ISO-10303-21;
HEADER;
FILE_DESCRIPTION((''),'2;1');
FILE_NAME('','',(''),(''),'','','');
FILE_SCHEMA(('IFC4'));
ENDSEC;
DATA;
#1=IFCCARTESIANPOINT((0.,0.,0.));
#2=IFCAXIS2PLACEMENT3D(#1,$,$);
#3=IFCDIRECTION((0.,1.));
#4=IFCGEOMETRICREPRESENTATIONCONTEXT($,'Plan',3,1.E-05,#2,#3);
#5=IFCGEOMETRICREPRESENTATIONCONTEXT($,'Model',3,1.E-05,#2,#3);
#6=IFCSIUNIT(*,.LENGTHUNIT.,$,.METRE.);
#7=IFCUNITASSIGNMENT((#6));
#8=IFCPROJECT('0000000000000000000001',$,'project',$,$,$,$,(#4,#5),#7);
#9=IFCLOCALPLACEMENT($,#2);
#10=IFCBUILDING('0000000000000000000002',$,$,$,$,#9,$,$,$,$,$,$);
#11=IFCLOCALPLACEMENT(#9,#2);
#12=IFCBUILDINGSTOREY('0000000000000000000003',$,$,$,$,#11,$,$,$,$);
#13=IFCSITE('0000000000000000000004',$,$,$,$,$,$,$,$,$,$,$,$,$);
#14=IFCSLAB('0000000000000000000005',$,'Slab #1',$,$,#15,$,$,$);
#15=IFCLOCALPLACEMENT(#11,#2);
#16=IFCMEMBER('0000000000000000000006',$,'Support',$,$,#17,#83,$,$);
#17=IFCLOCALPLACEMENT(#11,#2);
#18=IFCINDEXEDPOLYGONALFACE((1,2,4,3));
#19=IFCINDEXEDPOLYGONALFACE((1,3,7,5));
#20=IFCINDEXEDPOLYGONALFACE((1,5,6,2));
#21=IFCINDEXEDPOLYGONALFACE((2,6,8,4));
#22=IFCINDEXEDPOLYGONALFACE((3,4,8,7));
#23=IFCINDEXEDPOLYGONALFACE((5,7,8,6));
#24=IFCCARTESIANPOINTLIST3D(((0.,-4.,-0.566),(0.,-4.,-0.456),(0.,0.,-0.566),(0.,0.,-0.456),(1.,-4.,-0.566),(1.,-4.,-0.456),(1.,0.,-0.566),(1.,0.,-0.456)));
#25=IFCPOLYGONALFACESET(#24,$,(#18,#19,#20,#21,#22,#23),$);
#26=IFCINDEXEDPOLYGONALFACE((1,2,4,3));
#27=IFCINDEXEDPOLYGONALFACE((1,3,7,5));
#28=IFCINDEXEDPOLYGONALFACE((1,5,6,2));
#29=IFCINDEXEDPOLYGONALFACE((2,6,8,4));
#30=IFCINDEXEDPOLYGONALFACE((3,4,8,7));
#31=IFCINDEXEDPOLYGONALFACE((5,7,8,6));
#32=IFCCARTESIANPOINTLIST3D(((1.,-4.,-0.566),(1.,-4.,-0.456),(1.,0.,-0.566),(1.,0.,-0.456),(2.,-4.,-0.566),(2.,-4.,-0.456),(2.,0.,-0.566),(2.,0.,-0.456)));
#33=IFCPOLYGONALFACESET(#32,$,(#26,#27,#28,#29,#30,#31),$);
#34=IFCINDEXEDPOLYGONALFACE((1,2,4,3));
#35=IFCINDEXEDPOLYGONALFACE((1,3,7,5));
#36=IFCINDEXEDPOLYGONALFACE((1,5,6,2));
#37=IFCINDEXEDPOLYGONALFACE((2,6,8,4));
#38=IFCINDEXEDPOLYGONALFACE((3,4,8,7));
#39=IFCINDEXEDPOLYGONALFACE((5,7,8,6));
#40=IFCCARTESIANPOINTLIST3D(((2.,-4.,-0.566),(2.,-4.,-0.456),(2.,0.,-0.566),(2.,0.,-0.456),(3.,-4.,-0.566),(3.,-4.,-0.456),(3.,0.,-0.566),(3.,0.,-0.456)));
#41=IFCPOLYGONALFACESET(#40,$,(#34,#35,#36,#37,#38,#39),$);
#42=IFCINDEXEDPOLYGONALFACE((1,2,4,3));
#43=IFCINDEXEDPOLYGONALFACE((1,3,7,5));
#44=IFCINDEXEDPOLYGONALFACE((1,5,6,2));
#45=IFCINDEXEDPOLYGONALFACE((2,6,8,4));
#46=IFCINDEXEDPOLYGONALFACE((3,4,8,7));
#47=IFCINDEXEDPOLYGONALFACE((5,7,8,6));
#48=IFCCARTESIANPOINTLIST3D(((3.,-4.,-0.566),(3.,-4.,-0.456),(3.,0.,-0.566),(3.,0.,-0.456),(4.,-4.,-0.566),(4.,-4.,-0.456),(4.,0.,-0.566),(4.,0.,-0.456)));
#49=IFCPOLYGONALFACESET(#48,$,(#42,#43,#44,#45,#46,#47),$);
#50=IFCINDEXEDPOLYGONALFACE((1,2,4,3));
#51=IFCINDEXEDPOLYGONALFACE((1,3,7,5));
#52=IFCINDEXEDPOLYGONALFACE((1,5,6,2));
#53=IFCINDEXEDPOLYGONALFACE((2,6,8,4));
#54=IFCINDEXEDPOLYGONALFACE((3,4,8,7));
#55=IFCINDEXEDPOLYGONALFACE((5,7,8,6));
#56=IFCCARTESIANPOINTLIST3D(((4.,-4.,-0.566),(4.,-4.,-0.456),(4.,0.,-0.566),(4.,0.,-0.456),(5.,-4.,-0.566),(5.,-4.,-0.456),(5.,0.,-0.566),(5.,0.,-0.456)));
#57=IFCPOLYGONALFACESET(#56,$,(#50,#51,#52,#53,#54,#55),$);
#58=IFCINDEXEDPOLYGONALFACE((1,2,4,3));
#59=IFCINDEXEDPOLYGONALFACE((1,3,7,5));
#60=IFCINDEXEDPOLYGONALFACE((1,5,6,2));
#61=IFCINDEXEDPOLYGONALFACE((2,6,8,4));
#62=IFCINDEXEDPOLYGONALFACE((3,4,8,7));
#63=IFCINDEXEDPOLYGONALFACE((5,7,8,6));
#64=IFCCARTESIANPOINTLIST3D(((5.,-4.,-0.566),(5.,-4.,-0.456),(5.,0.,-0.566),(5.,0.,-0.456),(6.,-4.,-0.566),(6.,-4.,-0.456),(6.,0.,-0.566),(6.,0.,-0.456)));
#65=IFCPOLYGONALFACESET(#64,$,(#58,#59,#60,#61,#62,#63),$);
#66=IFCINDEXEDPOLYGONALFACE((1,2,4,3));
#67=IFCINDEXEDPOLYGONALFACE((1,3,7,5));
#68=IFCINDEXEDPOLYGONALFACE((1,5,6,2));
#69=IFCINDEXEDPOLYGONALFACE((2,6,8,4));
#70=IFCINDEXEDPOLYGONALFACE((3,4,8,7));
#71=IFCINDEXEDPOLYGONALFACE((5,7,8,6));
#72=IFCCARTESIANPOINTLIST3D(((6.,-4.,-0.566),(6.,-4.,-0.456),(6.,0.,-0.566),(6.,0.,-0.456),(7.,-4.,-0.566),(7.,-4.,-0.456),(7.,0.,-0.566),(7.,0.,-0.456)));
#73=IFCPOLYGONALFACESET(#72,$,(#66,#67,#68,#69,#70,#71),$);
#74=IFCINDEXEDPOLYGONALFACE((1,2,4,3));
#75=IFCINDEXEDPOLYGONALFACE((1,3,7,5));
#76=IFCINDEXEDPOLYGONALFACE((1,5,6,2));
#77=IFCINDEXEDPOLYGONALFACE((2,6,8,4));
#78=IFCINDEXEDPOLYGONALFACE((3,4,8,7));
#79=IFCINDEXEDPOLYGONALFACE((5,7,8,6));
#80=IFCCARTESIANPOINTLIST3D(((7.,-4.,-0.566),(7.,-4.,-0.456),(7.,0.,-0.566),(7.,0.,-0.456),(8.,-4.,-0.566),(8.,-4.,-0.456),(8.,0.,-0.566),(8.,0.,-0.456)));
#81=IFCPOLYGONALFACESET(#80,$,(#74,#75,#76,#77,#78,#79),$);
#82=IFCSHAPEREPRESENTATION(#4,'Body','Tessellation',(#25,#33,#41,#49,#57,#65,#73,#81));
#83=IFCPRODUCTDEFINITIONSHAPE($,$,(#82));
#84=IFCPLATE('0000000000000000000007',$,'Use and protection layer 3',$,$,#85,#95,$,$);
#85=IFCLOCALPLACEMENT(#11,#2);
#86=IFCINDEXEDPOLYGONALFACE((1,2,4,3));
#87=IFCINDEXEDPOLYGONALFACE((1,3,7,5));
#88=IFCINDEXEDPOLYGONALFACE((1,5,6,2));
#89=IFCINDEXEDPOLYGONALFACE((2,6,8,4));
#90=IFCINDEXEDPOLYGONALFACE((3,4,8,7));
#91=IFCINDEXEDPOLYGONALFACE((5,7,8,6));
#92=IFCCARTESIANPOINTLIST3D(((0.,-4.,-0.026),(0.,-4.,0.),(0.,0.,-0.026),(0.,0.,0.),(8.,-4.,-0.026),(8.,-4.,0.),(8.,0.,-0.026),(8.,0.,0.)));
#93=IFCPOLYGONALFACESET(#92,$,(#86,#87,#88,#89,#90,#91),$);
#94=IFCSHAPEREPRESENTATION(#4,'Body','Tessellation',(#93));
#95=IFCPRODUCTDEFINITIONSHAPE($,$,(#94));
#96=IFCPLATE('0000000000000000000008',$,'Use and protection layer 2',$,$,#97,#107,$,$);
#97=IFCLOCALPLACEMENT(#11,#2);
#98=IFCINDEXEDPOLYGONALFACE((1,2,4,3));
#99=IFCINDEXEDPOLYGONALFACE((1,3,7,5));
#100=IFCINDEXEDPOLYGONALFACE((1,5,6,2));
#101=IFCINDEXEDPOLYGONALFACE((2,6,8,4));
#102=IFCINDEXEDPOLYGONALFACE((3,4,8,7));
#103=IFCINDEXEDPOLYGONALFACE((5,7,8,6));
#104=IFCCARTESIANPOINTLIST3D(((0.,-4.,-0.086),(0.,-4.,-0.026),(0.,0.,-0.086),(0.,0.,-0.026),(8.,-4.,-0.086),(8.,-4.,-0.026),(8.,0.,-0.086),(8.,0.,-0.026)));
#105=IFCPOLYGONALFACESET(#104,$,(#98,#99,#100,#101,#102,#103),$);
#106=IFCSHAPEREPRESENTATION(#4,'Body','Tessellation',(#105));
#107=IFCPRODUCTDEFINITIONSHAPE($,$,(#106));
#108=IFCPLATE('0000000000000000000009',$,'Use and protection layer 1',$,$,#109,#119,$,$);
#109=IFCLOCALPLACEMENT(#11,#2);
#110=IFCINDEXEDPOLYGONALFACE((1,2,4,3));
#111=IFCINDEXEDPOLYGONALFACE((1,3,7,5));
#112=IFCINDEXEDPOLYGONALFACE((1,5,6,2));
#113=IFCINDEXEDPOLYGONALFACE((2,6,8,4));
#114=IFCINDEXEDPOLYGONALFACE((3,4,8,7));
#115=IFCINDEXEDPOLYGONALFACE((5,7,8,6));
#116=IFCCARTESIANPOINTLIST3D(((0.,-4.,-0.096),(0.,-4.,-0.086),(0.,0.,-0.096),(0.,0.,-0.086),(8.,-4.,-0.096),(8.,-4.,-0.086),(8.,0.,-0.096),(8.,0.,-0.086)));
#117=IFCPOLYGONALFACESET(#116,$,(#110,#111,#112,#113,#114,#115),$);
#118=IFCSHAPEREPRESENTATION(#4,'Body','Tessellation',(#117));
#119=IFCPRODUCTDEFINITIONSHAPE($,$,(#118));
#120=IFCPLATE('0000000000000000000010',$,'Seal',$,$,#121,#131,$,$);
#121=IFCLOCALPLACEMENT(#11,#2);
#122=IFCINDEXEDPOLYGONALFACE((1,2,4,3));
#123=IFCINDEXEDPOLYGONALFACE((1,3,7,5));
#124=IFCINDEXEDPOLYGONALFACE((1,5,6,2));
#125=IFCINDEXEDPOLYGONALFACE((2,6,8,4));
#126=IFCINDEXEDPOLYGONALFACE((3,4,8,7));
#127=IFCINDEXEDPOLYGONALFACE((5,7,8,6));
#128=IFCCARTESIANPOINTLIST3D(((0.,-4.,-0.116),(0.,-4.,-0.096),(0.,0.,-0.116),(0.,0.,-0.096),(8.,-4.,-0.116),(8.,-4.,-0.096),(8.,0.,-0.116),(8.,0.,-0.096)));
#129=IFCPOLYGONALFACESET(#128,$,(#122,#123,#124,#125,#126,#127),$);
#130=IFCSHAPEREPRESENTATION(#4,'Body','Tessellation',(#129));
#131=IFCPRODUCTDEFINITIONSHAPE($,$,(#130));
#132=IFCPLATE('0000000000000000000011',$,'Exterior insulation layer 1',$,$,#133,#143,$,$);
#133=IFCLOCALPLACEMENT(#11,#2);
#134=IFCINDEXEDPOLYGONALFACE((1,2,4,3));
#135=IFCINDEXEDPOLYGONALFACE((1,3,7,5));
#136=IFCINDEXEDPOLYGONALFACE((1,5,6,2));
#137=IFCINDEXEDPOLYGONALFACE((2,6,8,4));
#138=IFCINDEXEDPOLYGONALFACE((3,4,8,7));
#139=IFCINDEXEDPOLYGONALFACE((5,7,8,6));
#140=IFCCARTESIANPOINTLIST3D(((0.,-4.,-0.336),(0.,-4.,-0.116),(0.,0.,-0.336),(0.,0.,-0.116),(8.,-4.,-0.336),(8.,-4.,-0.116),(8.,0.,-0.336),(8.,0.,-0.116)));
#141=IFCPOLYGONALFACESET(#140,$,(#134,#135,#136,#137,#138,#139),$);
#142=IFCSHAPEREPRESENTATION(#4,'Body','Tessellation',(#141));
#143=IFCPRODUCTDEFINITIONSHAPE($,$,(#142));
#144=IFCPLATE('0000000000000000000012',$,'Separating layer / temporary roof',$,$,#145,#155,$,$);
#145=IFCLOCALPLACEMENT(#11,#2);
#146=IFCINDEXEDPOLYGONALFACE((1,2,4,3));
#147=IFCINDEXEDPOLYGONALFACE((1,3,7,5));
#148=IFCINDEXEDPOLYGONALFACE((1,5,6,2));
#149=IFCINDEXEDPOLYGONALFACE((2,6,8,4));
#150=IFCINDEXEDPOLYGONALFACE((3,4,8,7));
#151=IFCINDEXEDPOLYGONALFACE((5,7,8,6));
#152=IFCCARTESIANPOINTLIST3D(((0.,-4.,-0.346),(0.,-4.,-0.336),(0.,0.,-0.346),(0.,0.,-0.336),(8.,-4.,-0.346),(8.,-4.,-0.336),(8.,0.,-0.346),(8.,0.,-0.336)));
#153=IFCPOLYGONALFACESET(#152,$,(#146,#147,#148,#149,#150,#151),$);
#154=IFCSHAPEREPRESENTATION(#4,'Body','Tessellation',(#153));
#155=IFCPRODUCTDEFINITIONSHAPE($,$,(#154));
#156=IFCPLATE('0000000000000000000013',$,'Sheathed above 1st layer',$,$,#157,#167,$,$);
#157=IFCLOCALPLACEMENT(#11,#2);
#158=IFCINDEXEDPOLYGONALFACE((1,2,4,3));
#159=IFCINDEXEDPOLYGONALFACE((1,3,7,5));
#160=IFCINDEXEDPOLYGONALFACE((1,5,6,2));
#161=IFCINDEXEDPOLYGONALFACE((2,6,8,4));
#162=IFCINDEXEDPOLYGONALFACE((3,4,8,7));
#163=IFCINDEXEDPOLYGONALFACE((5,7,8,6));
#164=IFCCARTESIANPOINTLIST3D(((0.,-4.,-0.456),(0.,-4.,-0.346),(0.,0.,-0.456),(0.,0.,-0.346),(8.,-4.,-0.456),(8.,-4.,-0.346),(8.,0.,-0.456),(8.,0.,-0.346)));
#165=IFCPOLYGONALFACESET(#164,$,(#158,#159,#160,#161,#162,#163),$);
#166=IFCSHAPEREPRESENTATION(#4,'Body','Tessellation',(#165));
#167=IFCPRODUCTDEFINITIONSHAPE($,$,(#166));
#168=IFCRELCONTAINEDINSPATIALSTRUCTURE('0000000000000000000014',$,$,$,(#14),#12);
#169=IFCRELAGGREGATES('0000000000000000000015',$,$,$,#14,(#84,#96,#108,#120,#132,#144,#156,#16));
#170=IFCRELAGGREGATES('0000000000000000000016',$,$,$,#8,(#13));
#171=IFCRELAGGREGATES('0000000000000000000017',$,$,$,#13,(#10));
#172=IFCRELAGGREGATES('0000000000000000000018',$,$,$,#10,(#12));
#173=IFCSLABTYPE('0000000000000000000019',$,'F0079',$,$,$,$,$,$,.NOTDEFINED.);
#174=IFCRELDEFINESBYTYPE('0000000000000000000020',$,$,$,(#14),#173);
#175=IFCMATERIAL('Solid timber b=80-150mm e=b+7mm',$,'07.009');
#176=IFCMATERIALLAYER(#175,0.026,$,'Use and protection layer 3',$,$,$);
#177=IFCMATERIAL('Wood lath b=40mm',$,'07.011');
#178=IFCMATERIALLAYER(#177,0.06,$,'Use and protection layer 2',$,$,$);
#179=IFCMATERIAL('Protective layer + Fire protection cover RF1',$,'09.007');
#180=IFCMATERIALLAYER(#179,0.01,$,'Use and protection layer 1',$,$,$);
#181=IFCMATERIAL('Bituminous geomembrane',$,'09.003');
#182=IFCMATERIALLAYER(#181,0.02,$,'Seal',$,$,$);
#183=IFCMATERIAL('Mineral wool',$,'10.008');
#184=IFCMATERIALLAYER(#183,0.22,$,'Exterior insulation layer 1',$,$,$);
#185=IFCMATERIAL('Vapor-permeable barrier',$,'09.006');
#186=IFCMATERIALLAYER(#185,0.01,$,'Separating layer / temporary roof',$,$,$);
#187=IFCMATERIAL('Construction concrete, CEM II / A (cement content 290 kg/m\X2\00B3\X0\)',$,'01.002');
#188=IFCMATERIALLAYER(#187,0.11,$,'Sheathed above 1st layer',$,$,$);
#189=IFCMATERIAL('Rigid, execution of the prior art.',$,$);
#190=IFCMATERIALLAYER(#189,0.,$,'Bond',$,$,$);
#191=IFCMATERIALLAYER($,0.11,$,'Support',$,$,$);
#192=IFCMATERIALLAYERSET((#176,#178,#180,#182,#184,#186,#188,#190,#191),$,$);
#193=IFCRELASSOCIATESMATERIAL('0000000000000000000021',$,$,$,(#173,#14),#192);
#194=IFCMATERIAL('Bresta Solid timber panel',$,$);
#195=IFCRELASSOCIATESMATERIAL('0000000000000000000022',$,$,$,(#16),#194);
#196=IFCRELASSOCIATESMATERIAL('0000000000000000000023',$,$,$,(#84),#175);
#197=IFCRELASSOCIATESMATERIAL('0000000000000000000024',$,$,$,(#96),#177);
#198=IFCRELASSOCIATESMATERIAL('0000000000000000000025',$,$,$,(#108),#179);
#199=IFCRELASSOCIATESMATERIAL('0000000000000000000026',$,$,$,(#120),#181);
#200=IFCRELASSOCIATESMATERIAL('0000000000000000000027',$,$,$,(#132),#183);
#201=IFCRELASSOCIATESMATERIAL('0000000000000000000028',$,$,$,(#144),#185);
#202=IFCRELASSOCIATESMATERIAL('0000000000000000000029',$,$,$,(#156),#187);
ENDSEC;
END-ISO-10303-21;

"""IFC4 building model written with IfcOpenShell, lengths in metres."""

from ifc_helpers import new_model, si_unit, direction, frame, frame_2d, origin, origin_with_axes, place, context, project, spatial, rectangle, extrude, material, layer, layer_set, type_object, element, aggregate, save


model = new_model("IFC4")

# Units and contexts
plan_context = context("Plan", 3, precision=1e-05, world=origin(), true_north=direction((0.0, 1.0)))
model_context = context("Model", 3, precision=1e-05, world=origin(), true_north=direction((0.0, 1.0)))
ifc_project = project(units=[si_unit("LENGTHUNIT", "METRE")], contexts=[plan_context, model_context])

# Site, building, storey
site = spatial("IfcSite", under=ifc_project)
building_placement = place(None, origin())
building = spatial("IfcBuilding", under=site, at=building_placement)
storey_placement = place(building_placement, origin())
storey = spatial("IfcBuildingStorey", under=building, at=storey_placement)

# Slab, member, plates
ifc_material_1 = material(Name="Solid timber b=80-150mm e=b+7mm", Category="07.009")
ifc_layer_1 = layer(ifc_material_1, 0.026, Name="Use and protection layer 3")
ifc_material_2 = material(Name="Wood lath b=40mm", Category="07.011")
ifc_layer_2 = layer(ifc_material_2, 0.06, Name="Use and protection layer 2")
ifc_material_3 = material(Name="Protective layer + Fire protection cover RF1", Category="09.007")
ifc_layer_3 = layer(ifc_material_3, 0.01, Name="Use and protection layer 1")
ifc_material_4 = material(Name="Bituminous geomembrane", Category="09.003")
ifc_layer_4 = layer(ifc_material_4, 0.02, Name="Seal")
ifc_material_5 = material(Name="Mineral wool", Category="10.008")
ifc_layer_5 = layer(ifc_material_5, 0.22, Name="Exterior insulation layer 1")
ifc_material_6 = material(Name="Vapor-permeable barrier", Category="09.006")
ifc_layer_6 = layer(ifc_material_6, 0.01, Name="Separating layer / temporary roof")
ifc_material_7 = material(Name="Construction concrete, CEM II / A (cement content 290 kg/m³)", Category="01.002")
ifc_layer_7 = layer(ifc_material_7, 0.11, Name="Sheathed above 1st layer")
ifc_material_8 = material(Name="Rigid, execution of the prior art.")
ifc_layer_8 = layer(ifc_material_8, 0.0, Name="Bond")
ifc_layer_9 = layer(None, 0.11, Name="Support")
ifc_layer_set = layer_set([ifc_layer_1, ifc_layer_2, ifc_layer_3, ifc_layer_4, ifc_layer_5, ifc_layer_6, ifc_layer_7, ifc_layer_8, ifc_layer_9])
slab_type = type_object("IfcSlabType", Name="F0079", PredefinedType="NOTDEFINED", material=ifc_layer_set)
slab_placement = place(None, frame((0.0, 0.0, 0.0), z_axis=(0.0, 0.0, -1.0), x_axis=(1.0, 0.0, 0.0)))
slab = element("IfcSlab", 1, at=slab_placement, inside=storey, type_object=slab_type, material=ifc_layer_set, Name="Slab #1")
ifc_material_9 = material(Name="Bresta Solid timber panel")
member_placement = place(slab_placement, origin())
member = element("IfcMember", 2, at=member_placement, material=ifc_material_9, Name="Support", context=plan_context, shape_type="SweptSolid", body=[
    extrude(rectangle(XDim=1.0, YDim=0.11, at=frame_2d((0.5, 0.055), x_axis=(1.0, 0.0))), frame((0.0, 4.0, 0.456), z_axis=(0.0, -1.0, 0.0), x_axis=(1.0, 0.0, 0.0)), (0.0, 0.0, 1.0), 4.0),
    extrude(rectangle(XDim=1.0, YDim=0.11, at=frame_2d((0.5, 0.055), x_axis=(1.0, 0.0))), frame((1.0, 4.0, 0.456), z_axis=(0.0, -1.0, 0.0), x_axis=(1.0, 0.0, 0.0)), (0.0, 0.0, 1.0), 4.0),
    extrude(rectangle(XDim=1.0, YDim=0.11, at=frame_2d((0.5, 0.055), x_axis=(1.0, 0.0))), frame((2.0, 4.0, 0.456), z_axis=(0.0, -1.0, 0.0), x_axis=(1.0, 0.0, 0.0)), (0.0, 0.0, 1.0), 4.0),
    extrude(rectangle(XDim=1.0, YDim=0.11, at=frame_2d((0.5, 0.055), x_axis=(1.0, 0.0))), frame((3.0, 4.0, 0.456), z_axis=(0.0, -1.0, 0.0), x_axis=(1.0, 0.0, 0.0)), (0.0, 0.0, 1.0), 4.0),
    extrude(rectangle(XDim=1.0, YDim=0.11, at=frame_2d((0.5, 0.055), x_axis=(1.0, 0.0))), frame((4.0, 4.0, 0.456), z_axis=(0.0, -1.0, 0.0), x_axis=(1.0, 0.0, 0.0)), (0.0, 0.0, 1.0), 4.0),
    extrude(rectangle(XDim=1.0, YDim=0.11, at=frame_2d((0.5, 0.055), x_axis=(1.0, 0.0))), frame((5.0, 4.0, 0.456), z_axis=(0.0, -1.0, 0.0), x_axis=(1.0, 0.0, 0.0)), (0.0, 0.0, 1.0), 4.0),
    extrude(rectangle(XDim=1.0, YDim=0.11, at=frame_2d((0.5, 0.055), x_axis=(1.0, 0.0))), frame((6.0, 4.0, 0.456), z_axis=(0.0, -1.0, 0.0), x_axis=(1.0, 0.0, 0.0)), (0.0, 0.0, 1.0), 4.0),
    extrude(rectangle(XDim=1.0, YDim=0.11, at=frame_2d((0.5, 0.055), x_axis=(1.0, 0.0))), frame((7.0, 4.0, 0.456), z_axis=(0.0, -1.0, 0.0), x_axis=(1.0, 0.0, 0.0)), (0.0, 0.0, 1.0), 4.0),
])
plate_1_placement = place(slab_placement, origin())
plate_1 = element("IfcPlate", 3, at=plate_1_placement, material=ifc_material_1, Name="Use and protection layer 3", context=plan_context, shape_type="SweptSolid", body=[
    extrude(rectangle(XDim=8.0, YDim=4.0, at=frame_2d((4.0, 2.0), x_axis=(1.0, 0.0))), origin_with_axes(), (0.0, 0.0, 1.0), 0.026),
])
plate_2_placement = place(slab_placement, origin())
plate_2 = element("IfcPlate", 4, at=plate_2_placement, material=ifc_material_2, Name="Use and protection layer 2", context=plan_context, shape_type="SweptSolid", body=[
    extrude(rectangle(XDim=8.0, YDim=4.0, at=frame_2d((4.0, 2.0), x_axis=(1.0, 0.0))), frame((0.0, 0.0, 0.026), z_axis=(0.0, 0.0, 1.0), x_axis=(1.0, 0.0, 0.0)), (0.0, 0.0, 1.0), 0.06),
])
plate_3_placement = place(slab_placement, origin())
plate_3 = element("IfcPlate", 5, at=plate_3_placement, material=ifc_material_3, Name="Use and protection layer 1", context=plan_context, shape_type="SweptSolid", body=[
    extrude(rectangle(XDim=8.0, YDim=4.0, at=frame_2d((4.0, 2.0), x_axis=(1.0, 0.0))), frame((0.0, 0.0, 0.086), z_axis=(0.0, 0.0, 1.0), x_axis=(1.0, 0.0, 0.0)), (0.0, 0.0, 1.0), 0.01),
])
plate_4_placement = place(slab_placement, origin())
plate_4 = element("IfcPlate", 6, at=plate_4_placement, material=ifc_material_4, Name="Seal", context=plan_context, shape_type="SweptSolid", body=[
    extrude(rectangle(XDim=8.0, YDim=4.0, at=frame_2d((4.0, 2.0), x_axis=(1.0, 0.0))), frame((0.0, 0.0, 0.096), z_axis=(0.0, 0.0, 1.0), x_axis=(1.0, 0.0, 0.0)), (0.0, 0.0, 1.0), 0.02),
])
plate_5_placement = place(slab_placement, origin())
plate_5 = element("IfcPlate", 7, at=plate_5_placement, material=ifc_material_5, Name="Exterior insulation layer 1", context=plan_context, shape_type="SweptSolid", body=[
    extrude(rectangle(XDim=8.0, YDim=4.0, at=frame_2d((4.0, 2.0), x_axis=(1.0, 0.0))), frame((0.0, 0.0, 0.116), z_axis=(0.0, 0.0, 1.0), x_axis=(1.0, 0.0, 0.0)), (0.0, 0.0, 1.0), 0.22),
])
plate_6_placement = place(slab_placement, origin())
plate_6 = element("IfcPlate", 8, at=plate_6_placement, material=ifc_material_6, Name="Separating layer / temporary roof", context=plan_context, shape_type="SweptSolid", body=[
    extrude(rectangle(XDim=8.0, YDim=4.0, at=frame_2d((4.0, 2.0), x_axis=(1.0, 0.0))), frame((0.0, 0.0, 0.336), z_axis=(0.0, 0.0, 1.0), x_axis=(1.0, 0.0, 0.0)), (0.0, 0.0, 1.0), 0.01),
])
plate_7_placement = place(slab_placement, origin())
plate_7 = element("IfcPlate", 9, at=plate_7_placement, material=ifc_material_7, Name="Sheathed above 1st layer", context=plan_context, shape_type="SweptSolid", body=[
    extrude(rectangle(XDim=8.0, YDim=4.0, at=frame_2d((4.0, 2.0), x_axis=(1.0, 0.0))), frame((0.0, 0.0, 0.346), z_axis=(0.0, 0.0, 1.0), x_axis=(1.0, 0.0, 0.0)), (0.0, 0.0, 1.0), 0.11),
])
aggregate(slab, [plate_1, plate_2, plate_3, plate_4, plate_5, plate_6, plate_7, member])

save(model, "model.ifc")
